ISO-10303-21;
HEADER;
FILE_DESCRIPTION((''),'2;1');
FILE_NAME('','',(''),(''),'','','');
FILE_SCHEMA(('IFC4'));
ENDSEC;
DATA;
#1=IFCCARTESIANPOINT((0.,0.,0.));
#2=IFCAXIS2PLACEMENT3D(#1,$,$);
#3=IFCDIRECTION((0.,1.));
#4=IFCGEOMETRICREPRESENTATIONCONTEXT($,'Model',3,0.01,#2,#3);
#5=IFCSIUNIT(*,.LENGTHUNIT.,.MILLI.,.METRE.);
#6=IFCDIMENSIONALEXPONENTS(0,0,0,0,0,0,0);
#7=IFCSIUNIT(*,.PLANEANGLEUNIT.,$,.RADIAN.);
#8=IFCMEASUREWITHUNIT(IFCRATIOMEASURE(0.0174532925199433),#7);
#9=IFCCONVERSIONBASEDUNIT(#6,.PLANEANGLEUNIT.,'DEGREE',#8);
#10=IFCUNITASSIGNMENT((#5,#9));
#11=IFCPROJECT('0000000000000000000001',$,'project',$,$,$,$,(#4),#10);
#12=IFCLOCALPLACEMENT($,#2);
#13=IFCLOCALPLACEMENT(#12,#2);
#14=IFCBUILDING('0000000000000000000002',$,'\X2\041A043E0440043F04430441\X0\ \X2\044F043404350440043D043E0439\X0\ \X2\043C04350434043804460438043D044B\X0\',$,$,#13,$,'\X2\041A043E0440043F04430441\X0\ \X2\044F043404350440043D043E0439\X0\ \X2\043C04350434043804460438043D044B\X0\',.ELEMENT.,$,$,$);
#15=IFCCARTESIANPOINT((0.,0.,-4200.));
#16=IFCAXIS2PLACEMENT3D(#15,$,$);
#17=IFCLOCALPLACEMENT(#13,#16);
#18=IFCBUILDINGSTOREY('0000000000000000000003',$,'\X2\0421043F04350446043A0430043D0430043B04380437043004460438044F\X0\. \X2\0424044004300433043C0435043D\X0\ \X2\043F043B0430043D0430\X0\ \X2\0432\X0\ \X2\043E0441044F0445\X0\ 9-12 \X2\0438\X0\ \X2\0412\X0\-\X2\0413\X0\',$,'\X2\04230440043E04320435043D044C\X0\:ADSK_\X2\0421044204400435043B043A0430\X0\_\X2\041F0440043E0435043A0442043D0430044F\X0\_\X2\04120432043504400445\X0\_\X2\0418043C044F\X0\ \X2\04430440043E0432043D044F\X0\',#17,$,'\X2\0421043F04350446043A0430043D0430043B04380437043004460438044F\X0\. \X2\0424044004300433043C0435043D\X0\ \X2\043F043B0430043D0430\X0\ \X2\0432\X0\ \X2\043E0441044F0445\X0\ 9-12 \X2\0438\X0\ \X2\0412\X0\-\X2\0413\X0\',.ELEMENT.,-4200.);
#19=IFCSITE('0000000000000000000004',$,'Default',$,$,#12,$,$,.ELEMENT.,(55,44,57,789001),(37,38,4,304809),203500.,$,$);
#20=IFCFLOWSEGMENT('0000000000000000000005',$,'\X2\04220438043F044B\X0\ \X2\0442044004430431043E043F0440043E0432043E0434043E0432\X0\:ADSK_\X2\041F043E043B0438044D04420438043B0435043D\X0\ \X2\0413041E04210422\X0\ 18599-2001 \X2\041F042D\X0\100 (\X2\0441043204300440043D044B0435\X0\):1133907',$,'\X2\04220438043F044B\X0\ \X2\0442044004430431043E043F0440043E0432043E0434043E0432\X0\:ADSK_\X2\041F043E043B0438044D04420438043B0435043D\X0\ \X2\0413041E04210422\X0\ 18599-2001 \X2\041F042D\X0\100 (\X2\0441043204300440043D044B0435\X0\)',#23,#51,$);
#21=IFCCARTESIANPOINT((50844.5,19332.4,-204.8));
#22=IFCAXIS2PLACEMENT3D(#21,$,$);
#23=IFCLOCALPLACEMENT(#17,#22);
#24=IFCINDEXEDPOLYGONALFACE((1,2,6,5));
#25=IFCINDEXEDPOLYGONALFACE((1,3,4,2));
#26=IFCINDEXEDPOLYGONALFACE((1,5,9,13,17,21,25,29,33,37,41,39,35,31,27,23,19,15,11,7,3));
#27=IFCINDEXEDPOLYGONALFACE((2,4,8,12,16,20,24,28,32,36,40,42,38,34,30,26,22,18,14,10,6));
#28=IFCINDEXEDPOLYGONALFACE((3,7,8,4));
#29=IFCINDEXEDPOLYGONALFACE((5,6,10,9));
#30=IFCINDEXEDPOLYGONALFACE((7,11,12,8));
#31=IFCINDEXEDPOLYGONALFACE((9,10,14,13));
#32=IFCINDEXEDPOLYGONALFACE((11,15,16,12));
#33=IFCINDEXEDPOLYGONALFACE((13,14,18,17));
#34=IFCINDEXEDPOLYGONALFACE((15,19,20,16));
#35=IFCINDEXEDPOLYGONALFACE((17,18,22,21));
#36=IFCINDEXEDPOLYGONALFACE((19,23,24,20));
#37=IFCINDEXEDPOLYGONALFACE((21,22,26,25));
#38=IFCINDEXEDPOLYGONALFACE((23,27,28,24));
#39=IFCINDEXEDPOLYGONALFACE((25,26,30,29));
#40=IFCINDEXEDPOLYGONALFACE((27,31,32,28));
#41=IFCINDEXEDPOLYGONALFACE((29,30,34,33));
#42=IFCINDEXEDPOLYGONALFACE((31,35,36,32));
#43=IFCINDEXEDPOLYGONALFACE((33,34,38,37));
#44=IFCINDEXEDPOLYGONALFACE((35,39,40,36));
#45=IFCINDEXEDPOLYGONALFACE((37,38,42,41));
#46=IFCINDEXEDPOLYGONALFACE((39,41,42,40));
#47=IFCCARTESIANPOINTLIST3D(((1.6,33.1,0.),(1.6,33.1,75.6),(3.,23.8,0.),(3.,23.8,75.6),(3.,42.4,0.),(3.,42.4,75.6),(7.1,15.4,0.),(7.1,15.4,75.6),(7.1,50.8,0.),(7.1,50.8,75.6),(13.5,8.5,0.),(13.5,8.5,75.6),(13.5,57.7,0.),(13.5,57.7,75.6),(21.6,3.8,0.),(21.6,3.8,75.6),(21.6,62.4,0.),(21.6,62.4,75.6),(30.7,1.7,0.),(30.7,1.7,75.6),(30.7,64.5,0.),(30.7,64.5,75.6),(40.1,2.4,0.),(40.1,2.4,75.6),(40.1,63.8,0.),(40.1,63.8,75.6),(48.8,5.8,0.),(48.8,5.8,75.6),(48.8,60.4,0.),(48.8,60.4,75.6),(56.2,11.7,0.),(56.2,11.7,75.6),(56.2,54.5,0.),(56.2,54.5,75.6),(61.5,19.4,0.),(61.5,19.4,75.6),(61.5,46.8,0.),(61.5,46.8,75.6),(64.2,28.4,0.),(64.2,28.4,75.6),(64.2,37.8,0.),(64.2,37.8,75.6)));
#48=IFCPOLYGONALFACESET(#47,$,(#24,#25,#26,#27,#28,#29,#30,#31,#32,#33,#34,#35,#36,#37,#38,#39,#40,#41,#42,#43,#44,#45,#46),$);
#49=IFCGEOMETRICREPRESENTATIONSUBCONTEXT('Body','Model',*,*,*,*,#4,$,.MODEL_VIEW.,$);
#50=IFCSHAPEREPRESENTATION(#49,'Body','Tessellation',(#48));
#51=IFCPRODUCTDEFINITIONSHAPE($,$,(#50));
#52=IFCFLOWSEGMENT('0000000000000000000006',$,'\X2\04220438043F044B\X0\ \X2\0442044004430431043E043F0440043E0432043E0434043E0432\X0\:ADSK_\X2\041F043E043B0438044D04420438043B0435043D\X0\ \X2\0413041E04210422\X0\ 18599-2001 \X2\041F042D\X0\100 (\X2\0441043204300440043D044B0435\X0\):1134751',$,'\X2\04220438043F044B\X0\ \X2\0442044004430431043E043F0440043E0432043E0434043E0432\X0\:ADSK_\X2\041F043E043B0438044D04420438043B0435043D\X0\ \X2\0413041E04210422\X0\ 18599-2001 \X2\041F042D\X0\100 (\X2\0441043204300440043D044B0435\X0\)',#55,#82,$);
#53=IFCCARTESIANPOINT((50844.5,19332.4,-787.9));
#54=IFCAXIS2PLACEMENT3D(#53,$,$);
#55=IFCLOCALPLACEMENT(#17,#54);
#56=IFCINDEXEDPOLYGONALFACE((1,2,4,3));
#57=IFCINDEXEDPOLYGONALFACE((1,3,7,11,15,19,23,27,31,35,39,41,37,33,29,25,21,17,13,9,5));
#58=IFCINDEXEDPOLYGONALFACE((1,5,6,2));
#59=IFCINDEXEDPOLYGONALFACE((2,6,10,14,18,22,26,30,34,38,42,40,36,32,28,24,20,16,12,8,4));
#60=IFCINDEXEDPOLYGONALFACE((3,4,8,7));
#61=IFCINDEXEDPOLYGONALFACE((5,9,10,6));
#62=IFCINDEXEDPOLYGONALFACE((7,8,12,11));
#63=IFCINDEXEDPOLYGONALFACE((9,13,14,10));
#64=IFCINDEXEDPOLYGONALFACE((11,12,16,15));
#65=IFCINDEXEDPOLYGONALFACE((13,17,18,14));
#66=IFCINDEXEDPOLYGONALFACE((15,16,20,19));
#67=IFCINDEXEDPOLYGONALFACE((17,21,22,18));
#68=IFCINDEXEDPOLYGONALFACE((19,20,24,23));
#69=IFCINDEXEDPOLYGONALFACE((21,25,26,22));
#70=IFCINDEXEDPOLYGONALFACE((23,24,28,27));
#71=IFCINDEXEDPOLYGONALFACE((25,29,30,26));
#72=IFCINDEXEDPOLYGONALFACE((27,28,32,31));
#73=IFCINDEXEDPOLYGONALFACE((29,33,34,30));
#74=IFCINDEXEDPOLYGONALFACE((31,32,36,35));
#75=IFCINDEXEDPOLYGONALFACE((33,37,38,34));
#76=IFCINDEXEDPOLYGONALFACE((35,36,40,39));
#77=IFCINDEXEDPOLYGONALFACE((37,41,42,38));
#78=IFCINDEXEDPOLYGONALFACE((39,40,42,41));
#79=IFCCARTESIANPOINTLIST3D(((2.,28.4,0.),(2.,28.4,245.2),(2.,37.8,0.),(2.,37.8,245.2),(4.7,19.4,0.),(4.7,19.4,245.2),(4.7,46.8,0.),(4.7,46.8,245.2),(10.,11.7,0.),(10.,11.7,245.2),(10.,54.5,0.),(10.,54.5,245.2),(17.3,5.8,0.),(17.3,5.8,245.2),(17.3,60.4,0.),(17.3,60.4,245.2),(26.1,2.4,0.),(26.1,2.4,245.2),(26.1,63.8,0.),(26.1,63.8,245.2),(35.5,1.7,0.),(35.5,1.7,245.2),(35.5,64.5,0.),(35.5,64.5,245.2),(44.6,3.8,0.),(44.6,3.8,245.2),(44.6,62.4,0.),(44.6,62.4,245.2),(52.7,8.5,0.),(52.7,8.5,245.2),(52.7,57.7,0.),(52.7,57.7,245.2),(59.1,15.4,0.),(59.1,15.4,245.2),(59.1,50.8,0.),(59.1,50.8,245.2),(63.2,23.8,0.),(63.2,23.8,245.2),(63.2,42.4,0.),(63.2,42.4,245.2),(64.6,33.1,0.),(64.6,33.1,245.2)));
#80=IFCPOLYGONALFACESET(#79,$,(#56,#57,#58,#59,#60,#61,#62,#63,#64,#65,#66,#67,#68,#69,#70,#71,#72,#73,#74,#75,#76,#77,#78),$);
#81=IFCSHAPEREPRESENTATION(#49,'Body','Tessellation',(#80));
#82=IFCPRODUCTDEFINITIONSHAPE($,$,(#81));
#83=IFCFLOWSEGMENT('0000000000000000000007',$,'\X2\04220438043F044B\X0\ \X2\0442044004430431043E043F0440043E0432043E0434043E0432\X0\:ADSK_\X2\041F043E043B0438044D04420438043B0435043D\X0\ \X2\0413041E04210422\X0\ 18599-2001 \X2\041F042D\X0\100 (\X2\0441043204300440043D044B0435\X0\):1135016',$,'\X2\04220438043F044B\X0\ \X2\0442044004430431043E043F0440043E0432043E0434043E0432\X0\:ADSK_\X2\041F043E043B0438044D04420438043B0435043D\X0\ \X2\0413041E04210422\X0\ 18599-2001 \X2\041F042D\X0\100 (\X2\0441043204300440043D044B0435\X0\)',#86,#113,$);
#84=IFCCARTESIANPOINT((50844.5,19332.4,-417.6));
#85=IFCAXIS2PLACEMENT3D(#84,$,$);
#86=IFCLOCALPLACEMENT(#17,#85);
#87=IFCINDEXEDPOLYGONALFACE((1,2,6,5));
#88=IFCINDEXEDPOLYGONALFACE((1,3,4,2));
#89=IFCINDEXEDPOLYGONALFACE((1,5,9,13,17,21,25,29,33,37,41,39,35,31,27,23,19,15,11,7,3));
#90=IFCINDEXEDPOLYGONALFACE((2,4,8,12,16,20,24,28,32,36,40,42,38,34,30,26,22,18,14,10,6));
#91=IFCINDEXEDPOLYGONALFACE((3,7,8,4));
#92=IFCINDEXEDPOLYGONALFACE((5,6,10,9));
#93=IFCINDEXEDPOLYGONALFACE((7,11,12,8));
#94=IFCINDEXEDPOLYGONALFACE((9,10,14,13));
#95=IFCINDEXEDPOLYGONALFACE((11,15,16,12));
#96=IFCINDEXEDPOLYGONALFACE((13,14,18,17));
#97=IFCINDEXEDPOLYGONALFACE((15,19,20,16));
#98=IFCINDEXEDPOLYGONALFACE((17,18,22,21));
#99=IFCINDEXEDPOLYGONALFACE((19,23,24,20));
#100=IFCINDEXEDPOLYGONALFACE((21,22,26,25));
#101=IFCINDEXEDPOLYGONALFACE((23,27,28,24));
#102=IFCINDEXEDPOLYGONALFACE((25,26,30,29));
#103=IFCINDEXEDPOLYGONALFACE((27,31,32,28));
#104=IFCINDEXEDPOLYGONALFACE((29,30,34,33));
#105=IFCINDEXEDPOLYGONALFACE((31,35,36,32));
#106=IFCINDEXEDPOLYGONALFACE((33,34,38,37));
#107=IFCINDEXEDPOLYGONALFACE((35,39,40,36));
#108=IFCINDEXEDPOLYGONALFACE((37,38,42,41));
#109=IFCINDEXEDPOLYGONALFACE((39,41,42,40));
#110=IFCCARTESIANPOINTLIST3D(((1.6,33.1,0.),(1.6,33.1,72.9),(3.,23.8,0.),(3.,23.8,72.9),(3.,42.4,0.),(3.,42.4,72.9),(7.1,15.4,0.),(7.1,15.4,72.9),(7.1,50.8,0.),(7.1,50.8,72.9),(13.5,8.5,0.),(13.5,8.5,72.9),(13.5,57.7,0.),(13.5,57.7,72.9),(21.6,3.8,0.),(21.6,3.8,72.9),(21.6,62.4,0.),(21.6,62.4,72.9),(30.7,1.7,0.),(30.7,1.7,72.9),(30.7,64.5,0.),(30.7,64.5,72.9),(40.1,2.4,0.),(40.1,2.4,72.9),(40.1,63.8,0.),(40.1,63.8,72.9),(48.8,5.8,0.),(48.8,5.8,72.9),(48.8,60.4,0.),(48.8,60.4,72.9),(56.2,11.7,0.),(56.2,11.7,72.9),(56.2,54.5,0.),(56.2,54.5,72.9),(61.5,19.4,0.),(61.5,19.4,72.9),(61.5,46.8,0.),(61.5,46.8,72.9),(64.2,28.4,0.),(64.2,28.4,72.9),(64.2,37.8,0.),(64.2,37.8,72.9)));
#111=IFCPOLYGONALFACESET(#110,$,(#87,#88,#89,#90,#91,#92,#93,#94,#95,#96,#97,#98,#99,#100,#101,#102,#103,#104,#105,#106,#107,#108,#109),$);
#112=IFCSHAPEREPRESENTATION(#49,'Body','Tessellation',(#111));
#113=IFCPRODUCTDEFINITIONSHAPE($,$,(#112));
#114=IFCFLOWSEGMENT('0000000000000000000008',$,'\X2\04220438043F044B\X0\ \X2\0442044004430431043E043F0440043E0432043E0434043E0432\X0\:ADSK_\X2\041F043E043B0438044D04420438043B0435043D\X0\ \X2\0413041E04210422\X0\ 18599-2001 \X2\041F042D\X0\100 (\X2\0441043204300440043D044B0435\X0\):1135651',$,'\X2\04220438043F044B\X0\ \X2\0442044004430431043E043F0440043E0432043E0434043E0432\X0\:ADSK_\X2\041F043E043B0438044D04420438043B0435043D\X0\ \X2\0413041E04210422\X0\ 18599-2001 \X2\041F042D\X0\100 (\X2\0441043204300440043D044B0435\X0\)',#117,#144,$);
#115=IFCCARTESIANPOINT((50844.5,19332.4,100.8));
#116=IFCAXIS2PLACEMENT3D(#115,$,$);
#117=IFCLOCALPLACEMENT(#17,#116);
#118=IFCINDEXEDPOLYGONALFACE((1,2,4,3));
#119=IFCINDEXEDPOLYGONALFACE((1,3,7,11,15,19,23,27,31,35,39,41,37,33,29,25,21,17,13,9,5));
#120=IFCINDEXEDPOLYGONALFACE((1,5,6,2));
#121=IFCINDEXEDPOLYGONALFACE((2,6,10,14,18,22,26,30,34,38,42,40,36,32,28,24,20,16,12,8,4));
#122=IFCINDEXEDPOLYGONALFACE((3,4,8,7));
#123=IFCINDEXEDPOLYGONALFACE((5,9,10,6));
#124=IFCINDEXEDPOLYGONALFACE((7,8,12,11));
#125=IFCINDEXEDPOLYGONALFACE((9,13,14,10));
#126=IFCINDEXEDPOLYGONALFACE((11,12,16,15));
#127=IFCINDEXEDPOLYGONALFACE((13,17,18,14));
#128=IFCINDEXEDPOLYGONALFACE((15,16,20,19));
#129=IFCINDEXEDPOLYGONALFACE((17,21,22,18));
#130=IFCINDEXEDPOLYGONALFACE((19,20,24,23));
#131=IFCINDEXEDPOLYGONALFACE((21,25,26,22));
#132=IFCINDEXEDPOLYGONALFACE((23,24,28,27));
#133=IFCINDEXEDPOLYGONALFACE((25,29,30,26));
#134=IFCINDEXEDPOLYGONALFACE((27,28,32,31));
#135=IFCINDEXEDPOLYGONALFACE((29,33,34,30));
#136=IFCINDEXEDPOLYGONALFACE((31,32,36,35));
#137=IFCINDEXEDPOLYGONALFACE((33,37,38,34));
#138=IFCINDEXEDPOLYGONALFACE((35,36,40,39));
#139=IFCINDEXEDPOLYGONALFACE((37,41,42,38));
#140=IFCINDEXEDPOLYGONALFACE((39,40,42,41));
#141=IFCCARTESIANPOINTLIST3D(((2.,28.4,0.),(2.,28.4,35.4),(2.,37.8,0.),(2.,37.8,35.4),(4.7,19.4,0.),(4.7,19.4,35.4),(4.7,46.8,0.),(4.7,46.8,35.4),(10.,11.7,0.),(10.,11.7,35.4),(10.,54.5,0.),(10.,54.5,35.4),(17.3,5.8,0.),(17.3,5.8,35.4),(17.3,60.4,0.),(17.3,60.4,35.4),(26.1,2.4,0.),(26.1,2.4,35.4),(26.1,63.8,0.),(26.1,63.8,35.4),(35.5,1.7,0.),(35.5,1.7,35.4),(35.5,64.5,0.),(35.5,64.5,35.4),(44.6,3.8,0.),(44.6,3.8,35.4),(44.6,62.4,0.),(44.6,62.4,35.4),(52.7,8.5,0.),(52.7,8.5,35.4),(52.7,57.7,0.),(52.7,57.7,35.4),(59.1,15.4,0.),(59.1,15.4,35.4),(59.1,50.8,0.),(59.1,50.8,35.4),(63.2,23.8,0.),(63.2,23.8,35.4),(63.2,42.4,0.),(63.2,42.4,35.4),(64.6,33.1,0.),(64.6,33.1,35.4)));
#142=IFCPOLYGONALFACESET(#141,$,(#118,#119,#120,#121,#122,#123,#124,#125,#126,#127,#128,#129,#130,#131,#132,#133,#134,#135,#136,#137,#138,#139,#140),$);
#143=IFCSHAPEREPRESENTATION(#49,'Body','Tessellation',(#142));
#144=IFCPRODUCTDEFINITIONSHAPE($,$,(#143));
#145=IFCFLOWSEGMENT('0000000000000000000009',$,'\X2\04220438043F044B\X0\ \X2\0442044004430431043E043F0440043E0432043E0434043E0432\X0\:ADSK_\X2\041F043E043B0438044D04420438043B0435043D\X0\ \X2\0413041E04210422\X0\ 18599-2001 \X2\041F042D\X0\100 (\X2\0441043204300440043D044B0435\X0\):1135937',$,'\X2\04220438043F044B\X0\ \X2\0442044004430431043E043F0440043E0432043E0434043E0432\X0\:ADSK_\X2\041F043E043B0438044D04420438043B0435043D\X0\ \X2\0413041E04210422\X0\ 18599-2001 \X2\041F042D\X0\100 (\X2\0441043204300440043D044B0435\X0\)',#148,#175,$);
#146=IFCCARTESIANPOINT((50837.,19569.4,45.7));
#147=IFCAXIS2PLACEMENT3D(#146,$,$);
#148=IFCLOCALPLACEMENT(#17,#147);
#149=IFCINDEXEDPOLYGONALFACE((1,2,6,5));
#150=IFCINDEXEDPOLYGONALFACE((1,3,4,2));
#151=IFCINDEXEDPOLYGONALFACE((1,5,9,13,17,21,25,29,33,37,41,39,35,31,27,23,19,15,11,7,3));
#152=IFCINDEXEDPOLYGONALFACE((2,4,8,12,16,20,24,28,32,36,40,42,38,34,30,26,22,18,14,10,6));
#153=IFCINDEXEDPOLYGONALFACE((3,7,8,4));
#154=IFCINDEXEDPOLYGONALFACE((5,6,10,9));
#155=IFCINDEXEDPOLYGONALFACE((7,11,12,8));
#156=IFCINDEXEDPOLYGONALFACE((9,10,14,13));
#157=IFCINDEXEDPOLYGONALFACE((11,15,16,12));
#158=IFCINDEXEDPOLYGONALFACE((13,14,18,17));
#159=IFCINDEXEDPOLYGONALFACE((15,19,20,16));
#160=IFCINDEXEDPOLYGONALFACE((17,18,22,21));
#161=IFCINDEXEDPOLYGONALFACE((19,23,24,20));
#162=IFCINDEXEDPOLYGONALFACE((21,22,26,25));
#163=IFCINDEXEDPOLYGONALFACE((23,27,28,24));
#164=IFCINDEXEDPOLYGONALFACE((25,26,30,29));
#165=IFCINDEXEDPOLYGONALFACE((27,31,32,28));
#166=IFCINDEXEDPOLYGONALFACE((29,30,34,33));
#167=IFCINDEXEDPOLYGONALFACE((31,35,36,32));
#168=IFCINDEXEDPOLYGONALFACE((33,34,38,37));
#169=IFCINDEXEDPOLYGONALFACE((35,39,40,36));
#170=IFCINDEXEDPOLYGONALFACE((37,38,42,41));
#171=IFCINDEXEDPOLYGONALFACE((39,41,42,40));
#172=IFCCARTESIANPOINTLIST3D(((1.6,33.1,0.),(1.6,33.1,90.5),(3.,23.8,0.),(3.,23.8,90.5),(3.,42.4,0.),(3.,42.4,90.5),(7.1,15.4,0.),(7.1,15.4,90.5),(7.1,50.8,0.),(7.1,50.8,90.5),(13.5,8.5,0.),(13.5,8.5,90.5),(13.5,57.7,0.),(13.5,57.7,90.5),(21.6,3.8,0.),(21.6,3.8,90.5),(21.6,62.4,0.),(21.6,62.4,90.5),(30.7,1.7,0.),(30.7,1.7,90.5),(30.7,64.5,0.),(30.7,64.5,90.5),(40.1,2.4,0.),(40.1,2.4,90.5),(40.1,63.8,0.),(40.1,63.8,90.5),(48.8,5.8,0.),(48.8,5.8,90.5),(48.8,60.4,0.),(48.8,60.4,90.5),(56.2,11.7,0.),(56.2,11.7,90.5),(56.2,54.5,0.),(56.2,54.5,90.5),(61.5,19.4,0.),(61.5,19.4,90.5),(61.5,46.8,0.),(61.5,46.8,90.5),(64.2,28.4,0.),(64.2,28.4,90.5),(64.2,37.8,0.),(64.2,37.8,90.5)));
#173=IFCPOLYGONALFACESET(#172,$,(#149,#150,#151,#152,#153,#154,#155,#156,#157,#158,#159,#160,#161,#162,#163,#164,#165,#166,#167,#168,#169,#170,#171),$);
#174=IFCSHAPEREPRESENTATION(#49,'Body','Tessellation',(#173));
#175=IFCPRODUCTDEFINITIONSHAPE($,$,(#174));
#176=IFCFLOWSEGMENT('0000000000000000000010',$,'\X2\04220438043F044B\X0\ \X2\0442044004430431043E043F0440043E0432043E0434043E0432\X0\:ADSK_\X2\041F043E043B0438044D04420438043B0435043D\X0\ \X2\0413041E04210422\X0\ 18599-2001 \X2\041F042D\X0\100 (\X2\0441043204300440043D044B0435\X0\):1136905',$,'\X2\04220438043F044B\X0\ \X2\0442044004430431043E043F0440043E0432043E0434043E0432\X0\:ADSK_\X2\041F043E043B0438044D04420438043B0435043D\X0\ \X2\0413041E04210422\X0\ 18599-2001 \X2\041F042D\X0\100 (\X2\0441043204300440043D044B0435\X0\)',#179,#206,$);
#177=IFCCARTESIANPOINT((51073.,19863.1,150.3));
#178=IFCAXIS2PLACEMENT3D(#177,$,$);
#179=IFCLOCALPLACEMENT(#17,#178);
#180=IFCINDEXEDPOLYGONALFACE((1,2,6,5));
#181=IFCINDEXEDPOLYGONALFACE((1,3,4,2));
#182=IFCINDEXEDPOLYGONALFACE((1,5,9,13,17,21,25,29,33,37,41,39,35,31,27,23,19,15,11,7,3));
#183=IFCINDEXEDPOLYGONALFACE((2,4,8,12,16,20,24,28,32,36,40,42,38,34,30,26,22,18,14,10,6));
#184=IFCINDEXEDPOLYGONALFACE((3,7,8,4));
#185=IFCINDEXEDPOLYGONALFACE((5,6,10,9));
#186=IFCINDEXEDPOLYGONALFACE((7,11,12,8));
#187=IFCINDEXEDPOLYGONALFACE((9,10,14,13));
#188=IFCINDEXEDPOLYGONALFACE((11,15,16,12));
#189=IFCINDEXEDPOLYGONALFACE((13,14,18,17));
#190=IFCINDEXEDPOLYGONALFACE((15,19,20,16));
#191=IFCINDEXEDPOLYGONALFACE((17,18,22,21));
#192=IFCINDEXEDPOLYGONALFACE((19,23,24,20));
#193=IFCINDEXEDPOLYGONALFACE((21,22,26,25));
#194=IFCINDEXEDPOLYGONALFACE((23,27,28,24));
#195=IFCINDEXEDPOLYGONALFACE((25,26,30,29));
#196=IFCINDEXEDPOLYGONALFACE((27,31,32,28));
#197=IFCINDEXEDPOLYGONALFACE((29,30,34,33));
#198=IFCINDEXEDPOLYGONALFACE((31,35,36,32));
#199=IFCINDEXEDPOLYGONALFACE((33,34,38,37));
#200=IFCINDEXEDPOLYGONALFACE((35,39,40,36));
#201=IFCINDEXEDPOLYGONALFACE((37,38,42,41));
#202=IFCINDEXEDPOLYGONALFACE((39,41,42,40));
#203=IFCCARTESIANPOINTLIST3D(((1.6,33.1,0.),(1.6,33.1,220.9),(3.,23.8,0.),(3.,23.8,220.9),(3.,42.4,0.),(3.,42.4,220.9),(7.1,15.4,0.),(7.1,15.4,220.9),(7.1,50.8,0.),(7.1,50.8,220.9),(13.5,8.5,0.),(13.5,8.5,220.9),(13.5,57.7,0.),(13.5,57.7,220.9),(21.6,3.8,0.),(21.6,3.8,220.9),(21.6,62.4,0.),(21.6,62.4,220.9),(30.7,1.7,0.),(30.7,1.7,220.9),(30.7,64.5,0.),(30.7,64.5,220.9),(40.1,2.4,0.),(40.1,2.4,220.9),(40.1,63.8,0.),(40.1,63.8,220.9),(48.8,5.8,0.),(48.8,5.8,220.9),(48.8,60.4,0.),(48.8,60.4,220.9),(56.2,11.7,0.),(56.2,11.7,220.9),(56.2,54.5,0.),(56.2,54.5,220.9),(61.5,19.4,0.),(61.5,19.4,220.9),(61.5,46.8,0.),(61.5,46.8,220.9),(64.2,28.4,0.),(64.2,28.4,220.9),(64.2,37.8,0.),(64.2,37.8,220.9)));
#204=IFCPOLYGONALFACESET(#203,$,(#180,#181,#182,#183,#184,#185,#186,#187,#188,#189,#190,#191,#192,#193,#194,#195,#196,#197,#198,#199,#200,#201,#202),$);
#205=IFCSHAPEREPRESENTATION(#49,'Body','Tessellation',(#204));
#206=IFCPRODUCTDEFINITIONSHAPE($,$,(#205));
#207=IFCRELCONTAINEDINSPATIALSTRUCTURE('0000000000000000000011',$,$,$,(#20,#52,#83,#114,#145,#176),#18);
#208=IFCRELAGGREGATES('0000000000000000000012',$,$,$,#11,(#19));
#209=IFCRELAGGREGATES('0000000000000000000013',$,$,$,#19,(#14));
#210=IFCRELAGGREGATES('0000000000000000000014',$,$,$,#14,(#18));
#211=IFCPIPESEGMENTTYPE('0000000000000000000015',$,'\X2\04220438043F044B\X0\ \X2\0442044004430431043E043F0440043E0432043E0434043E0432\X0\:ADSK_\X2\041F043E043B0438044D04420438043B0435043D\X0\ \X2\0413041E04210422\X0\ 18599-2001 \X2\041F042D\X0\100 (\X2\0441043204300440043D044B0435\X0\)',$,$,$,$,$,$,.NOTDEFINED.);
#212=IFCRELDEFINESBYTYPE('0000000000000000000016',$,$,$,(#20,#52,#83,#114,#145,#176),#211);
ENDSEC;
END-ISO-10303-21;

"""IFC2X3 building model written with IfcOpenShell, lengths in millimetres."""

from ifc_helpers import new_model, entity, si_unit, converted_unit, direction, frame, origin, origin_2d_with_axis, place, context, subcontext, project, spatial, circle, extrude, type_object, element, save


model = new_model("IFC2X3")

# Units and contexts
model_context = context("Model", 3, precision=0.01, world=origin(), true_north=direction((0.0, 1.0)))
body_context = subcontext(model_context, "Body", "Model", "MODEL_VIEW")
ifc_project = project(units=[si_unit("LENGTHUNIT", "METRE", prefix="MILLI"), converted_unit("PLANEANGLEUNIT", "DEGREE", entity("IfcRatioMeasure", 0.0174532925199433), si_unit("PLANEANGLEUNIT", "RADIAN"), dimensions=[0, 0, 0, 0, 0, 0, 0])], contexts=[model_context])

# Site, building, storey
site_placement = place(None, origin())
site = spatial("IfcSite", under=ifc_project, at=site_placement, Name="Default", CompositionType="ELEMENT", RefLatitude=(55, 44, 57, 789001), RefLongitude=(37, 38, 4, 304809), RefElevation=203500.0)
building_placement = place(site_placement, origin())
building = spatial("IfcBuilding", under=site, at=building_placement, Name="Корпус ядерной медицины", LongName="Корпус ядерной медицины", CompositionType="ELEMENT")
storey_placement = place(building_placement, frame((0.0, 0.0, -4200.0)))
storey = spatial("IfcBuildingStorey", under=building, at=storey_placement, Name="Спецканализация. Фрагмен плана в осях 9-12 и В-Г", ObjectType="Уровень:ADSK_Стрелка_Проектная_Вверх_Имя уровня", LongName="Спецканализация. Фрагмен плана в осях 9-12 и В-Г", CompositionType="ELEMENT", Elevation=-4200.0)

# Flow segments
pipe_segment_type = type_object("IfcPipeSegmentType", Name="Типы трубопроводов:ADSK_Полиэтилен ГОСТ 18599-2001 ПЭ100 (сварные)", PredefinedType="NOTDEFINED")
flow_segment_1_placement = place(storey_placement, frame((50844.5, 19332.4, -204.8)))
element("IfcFlowSegment", 1, at=flow_segment_1_placement, inside=storey, type_object=pipe_segment_type, Name="Типы трубопроводов:ADSK_Полиэтилен ГОСТ 18599-2001 ПЭ100 (сварные):1133907", ObjectType="Типы трубопроводов:ADSK_Полиэтилен ГОСТ 18599-2001 ПЭ100 (сварные)", context=body_context, shape_type="SweptSolid", body=[
    extrude(circle(Radius=31.5, at=origin_2d_with_axis()), frame((33.1, 33.1, 0.0), z_axis=(0.0, 0.0, 1.0), x_axis=(-1.0, 0.0, 0.0)), (0.0, 0.0, 1.0), 75.6),
])
flow_segment_2_placement = place(storey_placement, frame((50844.5, 19332.4, -787.9)))
element("IfcFlowSegment", 2, at=flow_segment_2_placement, inside=storey, type_object=pipe_segment_type, Name="Типы трубопроводов:ADSK_Полиэтилен ГОСТ 18599-2001 ПЭ100 (сварные):1134751", ObjectType="Типы трубопроводов:ADSK_Полиэтилен ГОСТ 18599-2001 ПЭ100 (сварные)", context=body_context, shape_type="SweptSolid", body=[
    extrude(circle(Radius=31.5, at=origin_2d_with_axis()), frame((33.1, 33.1, 0.0)), (0.0, 0.0, 1.0), 245.2),
])
flow_segment_3_placement = place(storey_placement, frame((50844.5, 19332.4, -417.6)))
element("IfcFlowSegment", 3, at=flow_segment_3_placement, inside=storey, type_object=pipe_segment_type, Name="Типы трубопроводов:ADSK_Полиэтилен ГОСТ 18599-2001 ПЭ100 (сварные):1135016", ObjectType="Типы трубопроводов:ADSK_Полиэтилен ГОСТ 18599-2001 ПЭ100 (сварные)", context=body_context, shape_type="SweptSolid", body=[
    extrude(circle(Radius=31.5, at=origin_2d_with_axis()), frame((33.1, 33.1, 0.0), z_axis=(0.0, 0.0, 1.0), x_axis=(-1.0, 0.0, 0.0)), (0.0, 0.0, 1.0), 72.9),
])
flow_segment_4_placement = place(storey_placement, frame((50844.5, 19332.4, 100.8)))
element("IfcFlowSegment", 4, at=flow_segment_4_placement, inside=storey, type_object=pipe_segment_type, Name="Типы трубопроводов:ADSK_Полиэтилен ГОСТ 18599-2001 ПЭ100 (сварные):1135651", ObjectType="Типы трубопроводов:ADSK_Полиэтилен ГОСТ 18599-2001 ПЭ100 (сварные)", context=body_context, shape_type="SweptSolid", body=[
    extrude(circle(Radius=31.5, at=origin_2d_with_axis()), frame((33.1, 33.1, 0.0)), (0.0, 0.0, 1.0), 35.4),
])
flow_segment_5_placement = place(storey_placement, frame((50837.0, 19569.4, 45.7)))
element("IfcFlowSegment", 5, at=flow_segment_5_placement, inside=storey, type_object=pipe_segment_type, Name="Типы трубопроводов:ADSK_Полиэтилен ГОСТ 18599-2001 ПЭ100 (сварные):1135937", ObjectType="Типы трубопроводов:ADSK_Полиэтилен ГОСТ 18599-2001 ПЭ100 (сварные)", context=body_context, shape_type="SweptSolid", body=[
    extrude(circle(Radius=31.5, at=origin_2d_with_axis()), frame((33.1, 33.1, 0.0), z_axis=(0.0, 0.0, 1.0), x_axis=(-1.0, 0.0, 0.0)), (0.0, 0.0, 1.0), 90.5),
])
flow_segment_6_placement = place(storey_placement, frame((51073.0, 19863.1, 150.3)))
element("IfcFlowSegment", 6, at=flow_segment_6_placement, inside=storey, type_object=pipe_segment_type, Name="Типы трубопроводов:ADSK_Полиэтилен ГОСТ 18599-2001 ПЭ100 (сварные):1136905", ObjectType="Типы трубопроводов:ADSK_Полиэтилен ГОСТ 18599-2001 ПЭ100 (сварные)", context=body_context, shape_type="SweptSolid", body=[
    extrude(circle(Radius=31.5, at=origin_2d_with_axis()), frame((33.1, 33.1, 0.0), z_axis=(0.0, 0.0, 1.0), x_axis=(-1.0, 0.0, 0.0)), (0.0, 0.0, 1.0), 220.9),
])

save(model, "model.ifc")
